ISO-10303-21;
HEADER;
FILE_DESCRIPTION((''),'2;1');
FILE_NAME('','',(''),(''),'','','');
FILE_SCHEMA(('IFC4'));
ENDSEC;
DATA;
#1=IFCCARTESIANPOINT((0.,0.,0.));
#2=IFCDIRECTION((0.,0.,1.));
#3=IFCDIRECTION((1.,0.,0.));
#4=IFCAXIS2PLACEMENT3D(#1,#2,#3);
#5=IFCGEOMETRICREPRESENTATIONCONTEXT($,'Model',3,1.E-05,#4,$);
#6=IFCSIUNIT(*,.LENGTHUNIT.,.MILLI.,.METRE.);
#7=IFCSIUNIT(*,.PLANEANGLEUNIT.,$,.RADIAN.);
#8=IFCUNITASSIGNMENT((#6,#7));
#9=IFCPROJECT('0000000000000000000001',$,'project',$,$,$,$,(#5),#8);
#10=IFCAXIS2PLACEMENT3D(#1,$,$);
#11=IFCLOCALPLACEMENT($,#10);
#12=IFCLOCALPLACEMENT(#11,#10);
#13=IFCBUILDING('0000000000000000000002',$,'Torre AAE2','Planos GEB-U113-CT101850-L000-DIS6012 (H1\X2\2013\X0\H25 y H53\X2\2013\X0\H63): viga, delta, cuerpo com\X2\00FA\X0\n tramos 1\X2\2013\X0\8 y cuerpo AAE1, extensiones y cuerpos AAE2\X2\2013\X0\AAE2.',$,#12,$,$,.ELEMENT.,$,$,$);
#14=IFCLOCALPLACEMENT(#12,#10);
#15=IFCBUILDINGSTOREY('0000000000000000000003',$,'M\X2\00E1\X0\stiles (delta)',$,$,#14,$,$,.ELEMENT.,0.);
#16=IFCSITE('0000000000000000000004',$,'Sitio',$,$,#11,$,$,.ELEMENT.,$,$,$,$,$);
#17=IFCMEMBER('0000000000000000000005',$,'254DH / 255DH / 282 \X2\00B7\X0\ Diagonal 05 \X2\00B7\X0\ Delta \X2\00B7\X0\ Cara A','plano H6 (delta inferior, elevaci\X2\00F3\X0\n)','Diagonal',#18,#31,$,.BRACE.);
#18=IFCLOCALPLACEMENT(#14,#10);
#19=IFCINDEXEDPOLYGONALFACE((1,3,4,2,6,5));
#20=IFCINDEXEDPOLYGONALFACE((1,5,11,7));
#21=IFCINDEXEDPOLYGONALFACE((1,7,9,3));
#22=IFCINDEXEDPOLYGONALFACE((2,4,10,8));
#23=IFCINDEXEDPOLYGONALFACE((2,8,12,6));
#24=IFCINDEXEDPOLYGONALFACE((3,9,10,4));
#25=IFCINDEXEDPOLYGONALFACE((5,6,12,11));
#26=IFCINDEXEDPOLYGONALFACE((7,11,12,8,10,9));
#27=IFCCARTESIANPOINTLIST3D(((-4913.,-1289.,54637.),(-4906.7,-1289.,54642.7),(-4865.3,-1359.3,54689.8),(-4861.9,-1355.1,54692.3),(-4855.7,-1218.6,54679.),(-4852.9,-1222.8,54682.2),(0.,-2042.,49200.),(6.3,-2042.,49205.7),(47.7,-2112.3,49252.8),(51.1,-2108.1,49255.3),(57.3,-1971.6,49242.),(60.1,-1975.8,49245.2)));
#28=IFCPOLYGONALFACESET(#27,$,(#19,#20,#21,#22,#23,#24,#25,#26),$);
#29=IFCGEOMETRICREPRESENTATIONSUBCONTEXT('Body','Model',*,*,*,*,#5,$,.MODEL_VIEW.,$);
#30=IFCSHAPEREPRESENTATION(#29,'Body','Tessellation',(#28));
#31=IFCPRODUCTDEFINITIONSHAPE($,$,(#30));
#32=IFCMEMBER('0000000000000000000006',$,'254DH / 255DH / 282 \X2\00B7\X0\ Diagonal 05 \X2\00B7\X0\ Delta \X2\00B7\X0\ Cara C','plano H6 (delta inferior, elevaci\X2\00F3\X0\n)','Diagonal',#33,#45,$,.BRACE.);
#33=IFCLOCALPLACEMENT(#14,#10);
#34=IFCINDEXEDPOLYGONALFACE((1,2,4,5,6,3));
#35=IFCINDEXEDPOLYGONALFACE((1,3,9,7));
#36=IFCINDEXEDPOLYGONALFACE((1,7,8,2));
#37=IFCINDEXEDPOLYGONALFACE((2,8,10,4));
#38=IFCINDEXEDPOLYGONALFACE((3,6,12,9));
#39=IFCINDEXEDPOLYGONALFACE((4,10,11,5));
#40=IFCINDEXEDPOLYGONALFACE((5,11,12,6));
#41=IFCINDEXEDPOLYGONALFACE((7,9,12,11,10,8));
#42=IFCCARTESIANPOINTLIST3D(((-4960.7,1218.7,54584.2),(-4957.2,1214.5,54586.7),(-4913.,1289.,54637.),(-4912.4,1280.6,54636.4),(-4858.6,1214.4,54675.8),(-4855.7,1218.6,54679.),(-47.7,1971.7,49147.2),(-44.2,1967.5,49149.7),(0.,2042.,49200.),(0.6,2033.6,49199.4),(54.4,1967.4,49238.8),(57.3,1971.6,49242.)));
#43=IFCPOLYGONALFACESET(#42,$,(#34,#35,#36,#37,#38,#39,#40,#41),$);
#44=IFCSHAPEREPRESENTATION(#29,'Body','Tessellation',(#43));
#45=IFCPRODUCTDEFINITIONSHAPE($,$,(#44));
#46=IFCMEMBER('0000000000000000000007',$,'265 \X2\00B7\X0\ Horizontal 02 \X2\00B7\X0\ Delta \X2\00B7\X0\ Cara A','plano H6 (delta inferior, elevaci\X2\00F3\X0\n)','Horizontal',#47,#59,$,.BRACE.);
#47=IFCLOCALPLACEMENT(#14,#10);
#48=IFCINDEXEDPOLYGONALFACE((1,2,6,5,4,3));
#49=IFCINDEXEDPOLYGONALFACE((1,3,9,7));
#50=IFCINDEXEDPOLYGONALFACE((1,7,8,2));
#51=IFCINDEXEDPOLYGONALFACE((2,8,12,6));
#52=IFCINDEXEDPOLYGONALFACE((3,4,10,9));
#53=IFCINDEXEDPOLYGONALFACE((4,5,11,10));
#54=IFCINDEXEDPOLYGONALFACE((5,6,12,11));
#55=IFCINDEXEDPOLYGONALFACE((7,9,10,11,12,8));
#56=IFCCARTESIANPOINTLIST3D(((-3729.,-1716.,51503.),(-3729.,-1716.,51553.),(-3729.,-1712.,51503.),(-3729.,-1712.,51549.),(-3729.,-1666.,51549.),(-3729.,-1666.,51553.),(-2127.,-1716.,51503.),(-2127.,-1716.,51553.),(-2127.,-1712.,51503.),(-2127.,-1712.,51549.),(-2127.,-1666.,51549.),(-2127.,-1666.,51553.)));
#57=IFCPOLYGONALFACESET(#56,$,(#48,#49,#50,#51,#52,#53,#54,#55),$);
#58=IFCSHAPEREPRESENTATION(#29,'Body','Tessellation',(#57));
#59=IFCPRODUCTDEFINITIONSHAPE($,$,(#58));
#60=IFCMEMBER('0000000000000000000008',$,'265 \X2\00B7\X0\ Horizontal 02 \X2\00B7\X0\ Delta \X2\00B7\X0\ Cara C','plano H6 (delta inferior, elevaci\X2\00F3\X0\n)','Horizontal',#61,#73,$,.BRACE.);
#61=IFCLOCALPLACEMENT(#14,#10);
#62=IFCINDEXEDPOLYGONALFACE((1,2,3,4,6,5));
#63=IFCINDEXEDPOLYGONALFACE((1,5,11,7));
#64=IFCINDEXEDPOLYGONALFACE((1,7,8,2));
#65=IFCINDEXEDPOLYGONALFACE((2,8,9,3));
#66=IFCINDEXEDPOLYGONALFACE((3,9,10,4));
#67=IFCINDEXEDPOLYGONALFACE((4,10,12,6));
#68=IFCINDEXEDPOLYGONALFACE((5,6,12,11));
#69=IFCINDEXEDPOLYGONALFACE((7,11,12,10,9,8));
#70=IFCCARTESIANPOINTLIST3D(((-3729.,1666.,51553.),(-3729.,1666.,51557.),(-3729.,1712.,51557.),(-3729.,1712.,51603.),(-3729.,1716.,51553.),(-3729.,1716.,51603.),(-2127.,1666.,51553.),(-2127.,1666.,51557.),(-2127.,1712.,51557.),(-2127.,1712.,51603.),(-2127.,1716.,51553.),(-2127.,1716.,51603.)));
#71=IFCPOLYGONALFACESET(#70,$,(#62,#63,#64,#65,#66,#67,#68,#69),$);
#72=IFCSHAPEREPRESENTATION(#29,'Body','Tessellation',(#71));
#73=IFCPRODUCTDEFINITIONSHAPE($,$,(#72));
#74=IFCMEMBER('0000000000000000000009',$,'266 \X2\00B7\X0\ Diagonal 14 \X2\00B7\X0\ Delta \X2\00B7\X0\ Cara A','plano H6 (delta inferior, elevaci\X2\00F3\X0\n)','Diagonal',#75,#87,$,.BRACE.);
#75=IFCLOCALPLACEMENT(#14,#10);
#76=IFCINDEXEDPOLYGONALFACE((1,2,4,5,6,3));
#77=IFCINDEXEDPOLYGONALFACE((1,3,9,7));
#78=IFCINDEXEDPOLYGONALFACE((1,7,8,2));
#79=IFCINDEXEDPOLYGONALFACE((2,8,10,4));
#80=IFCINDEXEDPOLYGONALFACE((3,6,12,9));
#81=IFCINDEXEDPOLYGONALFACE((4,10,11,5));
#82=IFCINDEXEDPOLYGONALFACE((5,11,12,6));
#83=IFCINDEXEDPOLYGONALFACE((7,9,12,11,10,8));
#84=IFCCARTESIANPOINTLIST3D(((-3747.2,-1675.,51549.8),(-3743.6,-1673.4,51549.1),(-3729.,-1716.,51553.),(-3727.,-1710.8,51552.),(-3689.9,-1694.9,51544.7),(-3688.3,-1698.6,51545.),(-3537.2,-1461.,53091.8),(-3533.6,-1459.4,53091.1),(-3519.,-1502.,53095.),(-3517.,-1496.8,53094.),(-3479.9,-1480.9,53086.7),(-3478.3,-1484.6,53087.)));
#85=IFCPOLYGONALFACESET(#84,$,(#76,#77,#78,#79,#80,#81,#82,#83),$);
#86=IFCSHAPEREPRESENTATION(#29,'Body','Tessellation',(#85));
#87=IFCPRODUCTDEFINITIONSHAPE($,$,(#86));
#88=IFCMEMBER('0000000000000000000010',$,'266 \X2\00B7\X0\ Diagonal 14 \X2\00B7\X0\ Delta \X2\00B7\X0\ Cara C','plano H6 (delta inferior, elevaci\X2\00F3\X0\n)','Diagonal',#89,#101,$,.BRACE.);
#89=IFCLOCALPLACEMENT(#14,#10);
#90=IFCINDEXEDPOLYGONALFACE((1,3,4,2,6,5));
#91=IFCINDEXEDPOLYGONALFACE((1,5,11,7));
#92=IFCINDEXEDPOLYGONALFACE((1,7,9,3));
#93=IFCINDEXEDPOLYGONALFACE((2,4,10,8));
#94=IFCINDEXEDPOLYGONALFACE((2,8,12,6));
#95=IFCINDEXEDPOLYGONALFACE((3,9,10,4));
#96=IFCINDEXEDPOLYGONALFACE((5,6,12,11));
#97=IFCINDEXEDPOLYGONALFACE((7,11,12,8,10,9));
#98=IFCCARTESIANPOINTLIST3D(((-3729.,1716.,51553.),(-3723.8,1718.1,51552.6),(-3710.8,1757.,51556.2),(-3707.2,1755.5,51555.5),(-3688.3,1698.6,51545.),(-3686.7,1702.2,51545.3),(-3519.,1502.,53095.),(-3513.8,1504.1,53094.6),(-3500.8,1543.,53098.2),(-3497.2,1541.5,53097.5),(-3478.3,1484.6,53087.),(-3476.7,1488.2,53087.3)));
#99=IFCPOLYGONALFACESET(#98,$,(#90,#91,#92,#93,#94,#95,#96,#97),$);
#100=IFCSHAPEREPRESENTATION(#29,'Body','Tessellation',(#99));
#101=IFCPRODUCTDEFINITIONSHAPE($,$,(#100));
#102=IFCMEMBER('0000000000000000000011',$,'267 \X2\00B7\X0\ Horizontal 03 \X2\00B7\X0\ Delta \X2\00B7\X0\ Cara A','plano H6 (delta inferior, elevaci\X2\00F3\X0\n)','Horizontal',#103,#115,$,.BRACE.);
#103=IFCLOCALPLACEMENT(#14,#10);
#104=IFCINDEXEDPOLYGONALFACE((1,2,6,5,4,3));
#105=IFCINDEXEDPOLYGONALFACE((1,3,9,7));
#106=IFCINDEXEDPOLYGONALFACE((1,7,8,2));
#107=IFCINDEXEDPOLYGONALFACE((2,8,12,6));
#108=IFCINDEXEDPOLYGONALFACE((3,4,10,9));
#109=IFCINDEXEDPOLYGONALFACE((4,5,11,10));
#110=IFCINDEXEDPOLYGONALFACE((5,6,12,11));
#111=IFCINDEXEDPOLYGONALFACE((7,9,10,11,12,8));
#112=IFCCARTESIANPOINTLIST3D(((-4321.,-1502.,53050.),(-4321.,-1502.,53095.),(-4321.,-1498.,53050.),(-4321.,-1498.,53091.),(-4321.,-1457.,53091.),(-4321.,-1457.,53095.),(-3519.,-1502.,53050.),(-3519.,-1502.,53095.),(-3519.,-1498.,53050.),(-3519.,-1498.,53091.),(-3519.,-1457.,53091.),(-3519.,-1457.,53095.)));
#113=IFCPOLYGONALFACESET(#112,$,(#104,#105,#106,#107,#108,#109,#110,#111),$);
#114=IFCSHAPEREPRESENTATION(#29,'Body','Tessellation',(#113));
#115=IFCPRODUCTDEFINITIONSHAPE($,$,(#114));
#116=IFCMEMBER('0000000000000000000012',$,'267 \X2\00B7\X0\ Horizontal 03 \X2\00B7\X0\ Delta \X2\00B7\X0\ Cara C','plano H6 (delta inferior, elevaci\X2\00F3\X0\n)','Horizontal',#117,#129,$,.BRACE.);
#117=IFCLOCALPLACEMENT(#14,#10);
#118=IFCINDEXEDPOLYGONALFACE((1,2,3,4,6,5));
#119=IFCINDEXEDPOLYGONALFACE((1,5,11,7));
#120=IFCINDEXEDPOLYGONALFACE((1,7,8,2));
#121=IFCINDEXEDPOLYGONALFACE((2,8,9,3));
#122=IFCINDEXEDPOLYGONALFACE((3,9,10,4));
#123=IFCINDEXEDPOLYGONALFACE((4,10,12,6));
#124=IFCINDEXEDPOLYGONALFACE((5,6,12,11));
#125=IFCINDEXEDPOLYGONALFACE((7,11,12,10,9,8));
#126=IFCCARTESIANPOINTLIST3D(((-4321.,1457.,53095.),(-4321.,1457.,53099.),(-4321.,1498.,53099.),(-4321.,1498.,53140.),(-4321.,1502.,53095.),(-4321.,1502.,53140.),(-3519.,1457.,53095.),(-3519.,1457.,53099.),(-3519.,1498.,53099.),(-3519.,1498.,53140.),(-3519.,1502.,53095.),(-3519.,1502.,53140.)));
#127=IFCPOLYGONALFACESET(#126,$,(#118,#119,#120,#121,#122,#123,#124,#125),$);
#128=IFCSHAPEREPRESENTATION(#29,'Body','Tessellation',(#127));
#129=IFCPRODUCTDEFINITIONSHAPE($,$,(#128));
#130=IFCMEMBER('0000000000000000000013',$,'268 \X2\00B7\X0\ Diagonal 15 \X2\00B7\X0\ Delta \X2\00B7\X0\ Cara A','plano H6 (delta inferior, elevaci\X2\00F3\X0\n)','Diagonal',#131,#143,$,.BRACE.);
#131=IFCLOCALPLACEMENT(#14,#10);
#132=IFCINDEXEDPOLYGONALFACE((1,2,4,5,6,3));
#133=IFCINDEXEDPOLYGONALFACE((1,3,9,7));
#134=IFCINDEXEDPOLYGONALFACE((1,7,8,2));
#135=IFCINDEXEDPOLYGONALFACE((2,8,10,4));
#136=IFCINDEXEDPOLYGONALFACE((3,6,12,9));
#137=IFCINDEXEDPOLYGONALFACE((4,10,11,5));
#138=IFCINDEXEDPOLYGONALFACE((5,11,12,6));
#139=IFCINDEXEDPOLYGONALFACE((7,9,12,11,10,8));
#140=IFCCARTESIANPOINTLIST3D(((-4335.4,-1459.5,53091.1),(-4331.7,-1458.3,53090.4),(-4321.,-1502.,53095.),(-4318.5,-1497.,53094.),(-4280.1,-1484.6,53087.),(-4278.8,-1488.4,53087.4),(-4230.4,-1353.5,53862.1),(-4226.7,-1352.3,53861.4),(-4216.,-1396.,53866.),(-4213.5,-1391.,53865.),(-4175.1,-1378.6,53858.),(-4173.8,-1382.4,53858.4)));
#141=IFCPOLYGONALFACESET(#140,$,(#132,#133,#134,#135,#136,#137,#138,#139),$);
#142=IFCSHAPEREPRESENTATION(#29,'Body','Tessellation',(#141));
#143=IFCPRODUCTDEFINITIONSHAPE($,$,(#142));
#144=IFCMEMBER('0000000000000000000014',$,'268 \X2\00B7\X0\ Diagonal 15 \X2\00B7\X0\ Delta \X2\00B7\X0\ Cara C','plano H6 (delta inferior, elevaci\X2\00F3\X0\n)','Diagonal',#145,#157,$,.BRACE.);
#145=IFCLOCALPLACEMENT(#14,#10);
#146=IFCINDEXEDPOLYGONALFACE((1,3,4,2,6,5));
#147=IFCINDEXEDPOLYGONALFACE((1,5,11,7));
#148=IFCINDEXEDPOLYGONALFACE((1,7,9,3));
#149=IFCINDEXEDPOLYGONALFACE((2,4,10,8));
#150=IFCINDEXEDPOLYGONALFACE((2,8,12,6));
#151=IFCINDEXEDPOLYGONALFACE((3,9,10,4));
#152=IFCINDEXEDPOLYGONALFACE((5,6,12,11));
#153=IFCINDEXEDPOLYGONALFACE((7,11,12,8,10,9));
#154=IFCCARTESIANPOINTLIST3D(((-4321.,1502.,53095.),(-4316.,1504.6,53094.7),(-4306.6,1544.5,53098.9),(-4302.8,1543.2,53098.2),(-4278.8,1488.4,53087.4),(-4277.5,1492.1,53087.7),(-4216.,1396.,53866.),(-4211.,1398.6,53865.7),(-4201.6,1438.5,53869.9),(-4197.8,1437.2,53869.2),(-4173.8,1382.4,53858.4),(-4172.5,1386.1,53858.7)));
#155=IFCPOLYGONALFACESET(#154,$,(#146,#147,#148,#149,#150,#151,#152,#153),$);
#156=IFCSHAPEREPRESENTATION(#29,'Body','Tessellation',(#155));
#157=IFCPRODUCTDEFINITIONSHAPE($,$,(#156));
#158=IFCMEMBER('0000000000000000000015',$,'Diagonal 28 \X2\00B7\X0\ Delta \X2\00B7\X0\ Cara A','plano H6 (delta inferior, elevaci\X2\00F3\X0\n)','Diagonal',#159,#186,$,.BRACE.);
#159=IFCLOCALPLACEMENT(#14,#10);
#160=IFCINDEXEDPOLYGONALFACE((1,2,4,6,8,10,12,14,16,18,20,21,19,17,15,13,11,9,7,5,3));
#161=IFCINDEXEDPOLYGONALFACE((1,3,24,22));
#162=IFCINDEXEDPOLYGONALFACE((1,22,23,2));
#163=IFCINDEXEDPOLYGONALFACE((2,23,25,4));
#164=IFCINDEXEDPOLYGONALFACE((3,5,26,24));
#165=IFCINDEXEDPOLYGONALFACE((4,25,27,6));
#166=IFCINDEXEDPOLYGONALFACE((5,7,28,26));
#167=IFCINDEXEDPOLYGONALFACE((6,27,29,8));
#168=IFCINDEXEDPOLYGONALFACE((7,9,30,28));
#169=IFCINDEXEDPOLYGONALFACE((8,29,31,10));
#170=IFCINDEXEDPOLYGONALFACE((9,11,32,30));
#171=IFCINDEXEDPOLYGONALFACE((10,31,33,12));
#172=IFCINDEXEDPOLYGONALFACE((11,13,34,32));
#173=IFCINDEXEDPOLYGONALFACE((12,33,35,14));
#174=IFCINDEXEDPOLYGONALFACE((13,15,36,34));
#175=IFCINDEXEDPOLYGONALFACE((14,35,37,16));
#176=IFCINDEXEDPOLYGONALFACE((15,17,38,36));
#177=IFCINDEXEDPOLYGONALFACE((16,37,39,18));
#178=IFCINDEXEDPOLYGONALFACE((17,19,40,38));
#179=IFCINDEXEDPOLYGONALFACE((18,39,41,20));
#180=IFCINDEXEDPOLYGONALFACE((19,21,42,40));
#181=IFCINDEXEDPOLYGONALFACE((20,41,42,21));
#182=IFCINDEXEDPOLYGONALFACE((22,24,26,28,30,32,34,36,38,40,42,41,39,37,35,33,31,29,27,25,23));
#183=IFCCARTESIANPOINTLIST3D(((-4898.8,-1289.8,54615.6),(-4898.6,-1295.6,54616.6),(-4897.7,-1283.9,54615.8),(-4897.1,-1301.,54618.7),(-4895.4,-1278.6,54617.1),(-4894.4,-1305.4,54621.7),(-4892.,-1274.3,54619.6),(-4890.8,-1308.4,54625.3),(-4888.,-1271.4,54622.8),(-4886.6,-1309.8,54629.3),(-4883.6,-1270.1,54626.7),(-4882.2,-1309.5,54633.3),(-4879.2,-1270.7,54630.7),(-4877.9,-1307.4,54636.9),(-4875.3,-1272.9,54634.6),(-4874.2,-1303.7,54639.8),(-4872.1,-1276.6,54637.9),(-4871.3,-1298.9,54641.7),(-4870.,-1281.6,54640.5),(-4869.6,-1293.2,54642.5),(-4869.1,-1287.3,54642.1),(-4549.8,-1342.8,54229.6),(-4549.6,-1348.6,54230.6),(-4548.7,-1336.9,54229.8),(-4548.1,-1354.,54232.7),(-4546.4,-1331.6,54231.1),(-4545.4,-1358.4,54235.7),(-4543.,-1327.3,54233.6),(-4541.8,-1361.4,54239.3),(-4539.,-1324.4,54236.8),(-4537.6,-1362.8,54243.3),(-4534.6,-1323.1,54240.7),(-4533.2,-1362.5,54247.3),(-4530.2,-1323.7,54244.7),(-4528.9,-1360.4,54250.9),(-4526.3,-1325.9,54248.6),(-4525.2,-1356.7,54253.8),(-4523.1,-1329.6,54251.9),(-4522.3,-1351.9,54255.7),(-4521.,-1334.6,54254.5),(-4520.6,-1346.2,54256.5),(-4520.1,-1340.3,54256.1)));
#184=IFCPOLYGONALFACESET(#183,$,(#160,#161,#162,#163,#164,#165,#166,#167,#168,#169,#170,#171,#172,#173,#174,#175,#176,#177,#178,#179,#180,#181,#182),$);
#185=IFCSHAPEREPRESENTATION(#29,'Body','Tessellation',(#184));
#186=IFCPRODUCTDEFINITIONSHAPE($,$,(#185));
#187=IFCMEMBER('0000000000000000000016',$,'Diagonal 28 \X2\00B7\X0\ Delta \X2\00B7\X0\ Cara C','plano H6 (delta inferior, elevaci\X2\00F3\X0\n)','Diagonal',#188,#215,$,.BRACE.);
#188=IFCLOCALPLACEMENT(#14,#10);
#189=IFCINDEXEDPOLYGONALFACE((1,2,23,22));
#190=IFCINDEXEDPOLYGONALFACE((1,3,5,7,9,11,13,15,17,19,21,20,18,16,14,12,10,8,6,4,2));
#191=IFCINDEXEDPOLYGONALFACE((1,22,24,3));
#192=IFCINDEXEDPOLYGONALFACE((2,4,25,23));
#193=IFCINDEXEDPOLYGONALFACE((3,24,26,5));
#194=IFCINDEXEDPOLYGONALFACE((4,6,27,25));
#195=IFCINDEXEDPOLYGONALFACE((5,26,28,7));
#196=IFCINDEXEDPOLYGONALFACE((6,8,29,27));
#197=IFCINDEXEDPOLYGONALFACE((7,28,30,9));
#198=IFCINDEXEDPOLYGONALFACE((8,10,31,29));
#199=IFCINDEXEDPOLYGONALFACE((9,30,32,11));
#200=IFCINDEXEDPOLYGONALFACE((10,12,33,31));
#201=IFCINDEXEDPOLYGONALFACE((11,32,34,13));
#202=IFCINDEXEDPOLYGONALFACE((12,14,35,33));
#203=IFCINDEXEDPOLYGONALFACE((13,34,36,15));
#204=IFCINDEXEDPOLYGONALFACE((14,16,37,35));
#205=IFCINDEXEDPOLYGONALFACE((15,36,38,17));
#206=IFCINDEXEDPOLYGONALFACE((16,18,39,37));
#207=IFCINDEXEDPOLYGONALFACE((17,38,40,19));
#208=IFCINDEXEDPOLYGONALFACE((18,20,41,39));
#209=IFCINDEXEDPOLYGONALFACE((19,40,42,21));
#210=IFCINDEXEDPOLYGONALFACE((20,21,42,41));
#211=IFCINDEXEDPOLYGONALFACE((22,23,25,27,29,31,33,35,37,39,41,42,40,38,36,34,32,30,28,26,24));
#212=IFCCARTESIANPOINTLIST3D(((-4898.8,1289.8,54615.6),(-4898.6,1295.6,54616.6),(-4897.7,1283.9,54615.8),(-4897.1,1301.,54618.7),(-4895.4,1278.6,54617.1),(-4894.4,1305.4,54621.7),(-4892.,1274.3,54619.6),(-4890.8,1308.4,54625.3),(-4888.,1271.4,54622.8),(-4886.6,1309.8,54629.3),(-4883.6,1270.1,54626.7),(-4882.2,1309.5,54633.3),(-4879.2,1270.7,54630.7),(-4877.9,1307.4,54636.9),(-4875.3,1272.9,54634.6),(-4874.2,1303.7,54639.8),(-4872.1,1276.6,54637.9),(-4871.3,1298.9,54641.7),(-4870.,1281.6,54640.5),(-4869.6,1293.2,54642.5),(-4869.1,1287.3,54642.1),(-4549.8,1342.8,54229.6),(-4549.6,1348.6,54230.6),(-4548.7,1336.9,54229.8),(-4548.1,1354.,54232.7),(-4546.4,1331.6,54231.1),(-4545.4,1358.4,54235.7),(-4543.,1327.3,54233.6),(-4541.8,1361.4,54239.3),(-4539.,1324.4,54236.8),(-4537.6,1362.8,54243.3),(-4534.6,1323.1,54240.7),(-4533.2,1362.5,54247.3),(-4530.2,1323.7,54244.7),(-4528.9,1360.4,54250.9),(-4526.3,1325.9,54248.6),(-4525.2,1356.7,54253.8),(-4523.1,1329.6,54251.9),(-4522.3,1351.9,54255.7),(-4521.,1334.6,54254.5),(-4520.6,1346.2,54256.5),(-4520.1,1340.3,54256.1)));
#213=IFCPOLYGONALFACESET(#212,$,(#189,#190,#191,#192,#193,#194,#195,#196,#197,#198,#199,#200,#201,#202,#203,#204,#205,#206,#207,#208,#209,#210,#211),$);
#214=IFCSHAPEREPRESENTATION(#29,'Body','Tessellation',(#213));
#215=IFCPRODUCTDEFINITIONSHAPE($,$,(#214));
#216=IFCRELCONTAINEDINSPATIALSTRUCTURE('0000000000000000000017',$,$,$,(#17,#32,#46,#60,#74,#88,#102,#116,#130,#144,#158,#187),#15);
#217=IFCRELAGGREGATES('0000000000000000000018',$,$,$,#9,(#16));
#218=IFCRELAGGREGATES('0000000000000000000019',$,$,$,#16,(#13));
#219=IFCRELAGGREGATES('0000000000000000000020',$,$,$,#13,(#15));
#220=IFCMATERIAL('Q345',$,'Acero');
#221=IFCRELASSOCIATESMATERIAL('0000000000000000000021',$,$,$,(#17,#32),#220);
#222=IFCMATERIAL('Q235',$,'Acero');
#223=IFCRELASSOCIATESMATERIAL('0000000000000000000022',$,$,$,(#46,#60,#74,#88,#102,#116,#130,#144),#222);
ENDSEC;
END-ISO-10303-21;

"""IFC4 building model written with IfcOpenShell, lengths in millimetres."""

from ifc_helpers import new_model, si_unit, frame, frame_2d, origin, origin_with_axes, place, context, subcontext, project, spatial, circle, l_section, extrude, material, element, save


model = new_model("IFC4")

# Units and contexts
model_context = context("Model", 3, precision=1e-05, world=origin_with_axes())
body_context = subcontext(model_context, "Body", "Model", "MODEL_VIEW")
ifc_project = project(units=[si_unit("LENGTHUNIT", "METRE", prefix="MILLI"), si_unit("PLANEANGLEUNIT", "RADIAN")], contexts=[model_context])

# Site, building, storey
site_placement = place(None, origin())
site = spatial("IfcSite", under=ifc_project, at=site_placement, Name="Sitio", CompositionType="ELEMENT")
building_placement = place(site_placement, origin())
building = spatial("IfcBuilding", under=site, at=building_placement, Name="Torre AAE2", Description="Planos GEB-U113-CT101850-L000-DIS6012 (H1–H25 y H53–H63): viga, delta, cuerpo común tramos 1–8 y cuerpo AAE1, extensiones y cuerpos AAE2–AAE2.", CompositionType="ELEMENT")
storey_placement = place(building_placement, origin())
storey = spatial("IfcBuildingStorey", under=building, at=storey_placement, Name="Mástiles (delta)", CompositionType="ELEMENT", Elevation=0.0)

# Members
ifc_material_1 = material(Name="Q345", Category="Acero")
for number, where, z_axis, x_axis, name in (
    (1, (-4913.0, -1289.0, 54637.0), (0.666937, -0.102219, -0.738069), (0.572774, 0.703887, 0.420087), "254DH / 255DH / 282 · Diagonal 05 · Delta · Cara A"),
    (2, (-4913.0, 1289.0, 54637.0), (0.666937, 0.102219, -0.738069), (0.572774, -0.703887, 0.420087), "254DH / 255DH / 282 · Diagonal 05 · Delta · Cara C"),
):
    element("IfcMember", number, at=place(storey_placement, frame(where, z_axis=z_axis, x_axis=x_axis)), inside=storey, material=ifc_material_1, Name=name, Description="plano H6 (delta inferior, elevación)", ObjectType="Diagonal", PredefinedType="BRACE", context=body_context, shape_type="SweptSolid", body=[
        extrude(l_section(Depth=100.0, Width=100.0, Thickness=6.0, at=frame_2d((50.0, 50.0))), None, (0.0, 0.0, 1.0), 7366.5),
    ])
ifc_material_2 = material(Name="Q235", Category="Acero")
for number, where, z_axis, x_axis, name in (
    (3, (-2127.0, -1716.0, 51553.0), (-1.0, 0.0, 0.0), (0.0, 1.0, 0.0), "265 · Horizontal 02 · Delta · Cara A"),
    (4, (-2127.0, 1716.0, 51553.0), (-1.0, 0.0, 0.0), (0.0, -1.0, 0.0), "265 · Horizontal 02 · Delta · Cara C"),
):
    element("IfcMember", number, at=place(storey_placement, frame(where, z_axis=z_axis, x_axis=x_axis)), inside=storey, material=ifc_material_2, Name=name, Description="plano H6 (delta inferior, elevación)", ObjectType="Horizontal", PredefinedType="BRACE", context=body_context, shape_type="SweptSolid", body=[
        extrude(l_section(Depth=50.0, Width=50.0, Thickness=4.0, at=frame_2d((25.0, 25.0))), None, (0.0, 0.0, 1.0), 1602.0),
    ])
for number, where, z_axis, x_axis, name in (
    (5, (-3729.0, -1716.0, 51553.0), (0.133683, 0.136229, 0.981616), (0.904602, 0.387767, -0.177009), "266 · Diagonal 14 · Delta · Cara A"),
    (6, (-3729.0, 1716.0, 51553.0), (0.133683, -0.136229, 0.981616), (0.904602, -0.387767, -0.177009), "266 · Diagonal 14 · Delta · Cara C"),
):
    element("IfcMember", number, at=place(storey_placement, frame(where, z_axis=z_axis, x_axis=x_axis)), inside=storey, material=ifc_material_2, Name=name, Description="plano H6 (delta inferior, elevación)", ObjectType="Diagonal", PredefinedType="BRACE", context=body_context, shape_type="SweptSolid", body=[
        extrude(l_section(Depth=45.0, Width=45.0, Thickness=4.0, at=frame_2d((22.5, 22.5))), None, (0.0, 0.0, 1.0), 1570.9),
    ])
for number, where, z_axis, x_axis, name in (
    (7, (-3519.0, -1502.0, 53095.0), (-1.0, 0.0, 0.0), (0.0, 1.0, 0.0), "267 · Horizontal 03 · Delta · Cara A"),
    (8, (-3519.0, 1502.0, 53095.0), (-1.0, 0.0, 0.0), (0.0, -1.0, 0.0), "267 · Horizontal 03 · Delta · Cara C"),
):
    element("IfcMember", number, at=place(storey_placement, frame(where, z_axis=z_axis, x_axis=x_axis)), inside=storey, material=ifc_material_2, Name=name, Description="plano H6 (delta inferior, elevación)", ObjectType="Horizontal", PredefinedType="BRACE", context=body_context, shape_type="SweptSolid", body=[
        extrude(l_section(Depth=45.0, Width=45.0, Thickness=4.0, at=frame_2d((22.5, 22.5))), None, (0.0, 0.0, 1.0), 802.0),
    ])
for number, where, z_axis, x_axis, name in (
    (9, (-4321.0, -1502.0, 53095.0), (0.133706, 0.13498, 0.981786), (0.937849, 0.30291, -0.169368), "268 · Diagonal 15 · Delta · Cara A"),
    (10, (-4321.0, 1502.0, 53095.0), (0.133706, -0.13498, 0.981786), (0.937849, -0.30291, -0.169368), "268 · Diagonal 15 · Delta · Cara C"),
):
    element("IfcMember", number, at=place(storey_placement, frame(where, z_axis=z_axis, x_axis=x_axis)), inside=storey, material=ifc_material_2, Name=name, Description="plano H6 (delta inferior, elevación)", ObjectType="Diagonal", PredefinedType="BRACE", context=body_context, shape_type="SweptSolid", body=[
        extrude(l_section(Depth=45.0, Width=45.0, Thickness=4.0, at=frame_2d((22.5, 22.5))), None, (0.0, 0.0, 1.0), 785.3),
    ])
for number, where, z_axis, x_axis, name in (
    (11, (-4535.0, -1343.0, 54243.0), (-0.66721, 0.101324, 0.737946), (0.700938, 0.42061, 0.575998), "Diagonal 28 · Delta · Cara A"),
    (12, (-4535.0, 1343.0, 54243.0), (-0.66721, -0.101324, 0.737946), (0.700938, -0.42061, 0.575998), "Diagonal 28 · Delta · Cara C"),
):
    element("IfcMember", number, at=place(storey_placement, frame(where, z_axis=z_axis, x_axis=x_axis)), inside=storey, Name=name, Description="plano H6 (delta inferior, elevación)", ObjectType="Diagonal", PredefinedType="BRACE", context=body_context, shape_type="SweptSolid", body=[
        extrude(circle(Radius=20.0), None, (0.0, 0.0, 1.0), 523.1),
    ])

save(model, "model.ifc")
